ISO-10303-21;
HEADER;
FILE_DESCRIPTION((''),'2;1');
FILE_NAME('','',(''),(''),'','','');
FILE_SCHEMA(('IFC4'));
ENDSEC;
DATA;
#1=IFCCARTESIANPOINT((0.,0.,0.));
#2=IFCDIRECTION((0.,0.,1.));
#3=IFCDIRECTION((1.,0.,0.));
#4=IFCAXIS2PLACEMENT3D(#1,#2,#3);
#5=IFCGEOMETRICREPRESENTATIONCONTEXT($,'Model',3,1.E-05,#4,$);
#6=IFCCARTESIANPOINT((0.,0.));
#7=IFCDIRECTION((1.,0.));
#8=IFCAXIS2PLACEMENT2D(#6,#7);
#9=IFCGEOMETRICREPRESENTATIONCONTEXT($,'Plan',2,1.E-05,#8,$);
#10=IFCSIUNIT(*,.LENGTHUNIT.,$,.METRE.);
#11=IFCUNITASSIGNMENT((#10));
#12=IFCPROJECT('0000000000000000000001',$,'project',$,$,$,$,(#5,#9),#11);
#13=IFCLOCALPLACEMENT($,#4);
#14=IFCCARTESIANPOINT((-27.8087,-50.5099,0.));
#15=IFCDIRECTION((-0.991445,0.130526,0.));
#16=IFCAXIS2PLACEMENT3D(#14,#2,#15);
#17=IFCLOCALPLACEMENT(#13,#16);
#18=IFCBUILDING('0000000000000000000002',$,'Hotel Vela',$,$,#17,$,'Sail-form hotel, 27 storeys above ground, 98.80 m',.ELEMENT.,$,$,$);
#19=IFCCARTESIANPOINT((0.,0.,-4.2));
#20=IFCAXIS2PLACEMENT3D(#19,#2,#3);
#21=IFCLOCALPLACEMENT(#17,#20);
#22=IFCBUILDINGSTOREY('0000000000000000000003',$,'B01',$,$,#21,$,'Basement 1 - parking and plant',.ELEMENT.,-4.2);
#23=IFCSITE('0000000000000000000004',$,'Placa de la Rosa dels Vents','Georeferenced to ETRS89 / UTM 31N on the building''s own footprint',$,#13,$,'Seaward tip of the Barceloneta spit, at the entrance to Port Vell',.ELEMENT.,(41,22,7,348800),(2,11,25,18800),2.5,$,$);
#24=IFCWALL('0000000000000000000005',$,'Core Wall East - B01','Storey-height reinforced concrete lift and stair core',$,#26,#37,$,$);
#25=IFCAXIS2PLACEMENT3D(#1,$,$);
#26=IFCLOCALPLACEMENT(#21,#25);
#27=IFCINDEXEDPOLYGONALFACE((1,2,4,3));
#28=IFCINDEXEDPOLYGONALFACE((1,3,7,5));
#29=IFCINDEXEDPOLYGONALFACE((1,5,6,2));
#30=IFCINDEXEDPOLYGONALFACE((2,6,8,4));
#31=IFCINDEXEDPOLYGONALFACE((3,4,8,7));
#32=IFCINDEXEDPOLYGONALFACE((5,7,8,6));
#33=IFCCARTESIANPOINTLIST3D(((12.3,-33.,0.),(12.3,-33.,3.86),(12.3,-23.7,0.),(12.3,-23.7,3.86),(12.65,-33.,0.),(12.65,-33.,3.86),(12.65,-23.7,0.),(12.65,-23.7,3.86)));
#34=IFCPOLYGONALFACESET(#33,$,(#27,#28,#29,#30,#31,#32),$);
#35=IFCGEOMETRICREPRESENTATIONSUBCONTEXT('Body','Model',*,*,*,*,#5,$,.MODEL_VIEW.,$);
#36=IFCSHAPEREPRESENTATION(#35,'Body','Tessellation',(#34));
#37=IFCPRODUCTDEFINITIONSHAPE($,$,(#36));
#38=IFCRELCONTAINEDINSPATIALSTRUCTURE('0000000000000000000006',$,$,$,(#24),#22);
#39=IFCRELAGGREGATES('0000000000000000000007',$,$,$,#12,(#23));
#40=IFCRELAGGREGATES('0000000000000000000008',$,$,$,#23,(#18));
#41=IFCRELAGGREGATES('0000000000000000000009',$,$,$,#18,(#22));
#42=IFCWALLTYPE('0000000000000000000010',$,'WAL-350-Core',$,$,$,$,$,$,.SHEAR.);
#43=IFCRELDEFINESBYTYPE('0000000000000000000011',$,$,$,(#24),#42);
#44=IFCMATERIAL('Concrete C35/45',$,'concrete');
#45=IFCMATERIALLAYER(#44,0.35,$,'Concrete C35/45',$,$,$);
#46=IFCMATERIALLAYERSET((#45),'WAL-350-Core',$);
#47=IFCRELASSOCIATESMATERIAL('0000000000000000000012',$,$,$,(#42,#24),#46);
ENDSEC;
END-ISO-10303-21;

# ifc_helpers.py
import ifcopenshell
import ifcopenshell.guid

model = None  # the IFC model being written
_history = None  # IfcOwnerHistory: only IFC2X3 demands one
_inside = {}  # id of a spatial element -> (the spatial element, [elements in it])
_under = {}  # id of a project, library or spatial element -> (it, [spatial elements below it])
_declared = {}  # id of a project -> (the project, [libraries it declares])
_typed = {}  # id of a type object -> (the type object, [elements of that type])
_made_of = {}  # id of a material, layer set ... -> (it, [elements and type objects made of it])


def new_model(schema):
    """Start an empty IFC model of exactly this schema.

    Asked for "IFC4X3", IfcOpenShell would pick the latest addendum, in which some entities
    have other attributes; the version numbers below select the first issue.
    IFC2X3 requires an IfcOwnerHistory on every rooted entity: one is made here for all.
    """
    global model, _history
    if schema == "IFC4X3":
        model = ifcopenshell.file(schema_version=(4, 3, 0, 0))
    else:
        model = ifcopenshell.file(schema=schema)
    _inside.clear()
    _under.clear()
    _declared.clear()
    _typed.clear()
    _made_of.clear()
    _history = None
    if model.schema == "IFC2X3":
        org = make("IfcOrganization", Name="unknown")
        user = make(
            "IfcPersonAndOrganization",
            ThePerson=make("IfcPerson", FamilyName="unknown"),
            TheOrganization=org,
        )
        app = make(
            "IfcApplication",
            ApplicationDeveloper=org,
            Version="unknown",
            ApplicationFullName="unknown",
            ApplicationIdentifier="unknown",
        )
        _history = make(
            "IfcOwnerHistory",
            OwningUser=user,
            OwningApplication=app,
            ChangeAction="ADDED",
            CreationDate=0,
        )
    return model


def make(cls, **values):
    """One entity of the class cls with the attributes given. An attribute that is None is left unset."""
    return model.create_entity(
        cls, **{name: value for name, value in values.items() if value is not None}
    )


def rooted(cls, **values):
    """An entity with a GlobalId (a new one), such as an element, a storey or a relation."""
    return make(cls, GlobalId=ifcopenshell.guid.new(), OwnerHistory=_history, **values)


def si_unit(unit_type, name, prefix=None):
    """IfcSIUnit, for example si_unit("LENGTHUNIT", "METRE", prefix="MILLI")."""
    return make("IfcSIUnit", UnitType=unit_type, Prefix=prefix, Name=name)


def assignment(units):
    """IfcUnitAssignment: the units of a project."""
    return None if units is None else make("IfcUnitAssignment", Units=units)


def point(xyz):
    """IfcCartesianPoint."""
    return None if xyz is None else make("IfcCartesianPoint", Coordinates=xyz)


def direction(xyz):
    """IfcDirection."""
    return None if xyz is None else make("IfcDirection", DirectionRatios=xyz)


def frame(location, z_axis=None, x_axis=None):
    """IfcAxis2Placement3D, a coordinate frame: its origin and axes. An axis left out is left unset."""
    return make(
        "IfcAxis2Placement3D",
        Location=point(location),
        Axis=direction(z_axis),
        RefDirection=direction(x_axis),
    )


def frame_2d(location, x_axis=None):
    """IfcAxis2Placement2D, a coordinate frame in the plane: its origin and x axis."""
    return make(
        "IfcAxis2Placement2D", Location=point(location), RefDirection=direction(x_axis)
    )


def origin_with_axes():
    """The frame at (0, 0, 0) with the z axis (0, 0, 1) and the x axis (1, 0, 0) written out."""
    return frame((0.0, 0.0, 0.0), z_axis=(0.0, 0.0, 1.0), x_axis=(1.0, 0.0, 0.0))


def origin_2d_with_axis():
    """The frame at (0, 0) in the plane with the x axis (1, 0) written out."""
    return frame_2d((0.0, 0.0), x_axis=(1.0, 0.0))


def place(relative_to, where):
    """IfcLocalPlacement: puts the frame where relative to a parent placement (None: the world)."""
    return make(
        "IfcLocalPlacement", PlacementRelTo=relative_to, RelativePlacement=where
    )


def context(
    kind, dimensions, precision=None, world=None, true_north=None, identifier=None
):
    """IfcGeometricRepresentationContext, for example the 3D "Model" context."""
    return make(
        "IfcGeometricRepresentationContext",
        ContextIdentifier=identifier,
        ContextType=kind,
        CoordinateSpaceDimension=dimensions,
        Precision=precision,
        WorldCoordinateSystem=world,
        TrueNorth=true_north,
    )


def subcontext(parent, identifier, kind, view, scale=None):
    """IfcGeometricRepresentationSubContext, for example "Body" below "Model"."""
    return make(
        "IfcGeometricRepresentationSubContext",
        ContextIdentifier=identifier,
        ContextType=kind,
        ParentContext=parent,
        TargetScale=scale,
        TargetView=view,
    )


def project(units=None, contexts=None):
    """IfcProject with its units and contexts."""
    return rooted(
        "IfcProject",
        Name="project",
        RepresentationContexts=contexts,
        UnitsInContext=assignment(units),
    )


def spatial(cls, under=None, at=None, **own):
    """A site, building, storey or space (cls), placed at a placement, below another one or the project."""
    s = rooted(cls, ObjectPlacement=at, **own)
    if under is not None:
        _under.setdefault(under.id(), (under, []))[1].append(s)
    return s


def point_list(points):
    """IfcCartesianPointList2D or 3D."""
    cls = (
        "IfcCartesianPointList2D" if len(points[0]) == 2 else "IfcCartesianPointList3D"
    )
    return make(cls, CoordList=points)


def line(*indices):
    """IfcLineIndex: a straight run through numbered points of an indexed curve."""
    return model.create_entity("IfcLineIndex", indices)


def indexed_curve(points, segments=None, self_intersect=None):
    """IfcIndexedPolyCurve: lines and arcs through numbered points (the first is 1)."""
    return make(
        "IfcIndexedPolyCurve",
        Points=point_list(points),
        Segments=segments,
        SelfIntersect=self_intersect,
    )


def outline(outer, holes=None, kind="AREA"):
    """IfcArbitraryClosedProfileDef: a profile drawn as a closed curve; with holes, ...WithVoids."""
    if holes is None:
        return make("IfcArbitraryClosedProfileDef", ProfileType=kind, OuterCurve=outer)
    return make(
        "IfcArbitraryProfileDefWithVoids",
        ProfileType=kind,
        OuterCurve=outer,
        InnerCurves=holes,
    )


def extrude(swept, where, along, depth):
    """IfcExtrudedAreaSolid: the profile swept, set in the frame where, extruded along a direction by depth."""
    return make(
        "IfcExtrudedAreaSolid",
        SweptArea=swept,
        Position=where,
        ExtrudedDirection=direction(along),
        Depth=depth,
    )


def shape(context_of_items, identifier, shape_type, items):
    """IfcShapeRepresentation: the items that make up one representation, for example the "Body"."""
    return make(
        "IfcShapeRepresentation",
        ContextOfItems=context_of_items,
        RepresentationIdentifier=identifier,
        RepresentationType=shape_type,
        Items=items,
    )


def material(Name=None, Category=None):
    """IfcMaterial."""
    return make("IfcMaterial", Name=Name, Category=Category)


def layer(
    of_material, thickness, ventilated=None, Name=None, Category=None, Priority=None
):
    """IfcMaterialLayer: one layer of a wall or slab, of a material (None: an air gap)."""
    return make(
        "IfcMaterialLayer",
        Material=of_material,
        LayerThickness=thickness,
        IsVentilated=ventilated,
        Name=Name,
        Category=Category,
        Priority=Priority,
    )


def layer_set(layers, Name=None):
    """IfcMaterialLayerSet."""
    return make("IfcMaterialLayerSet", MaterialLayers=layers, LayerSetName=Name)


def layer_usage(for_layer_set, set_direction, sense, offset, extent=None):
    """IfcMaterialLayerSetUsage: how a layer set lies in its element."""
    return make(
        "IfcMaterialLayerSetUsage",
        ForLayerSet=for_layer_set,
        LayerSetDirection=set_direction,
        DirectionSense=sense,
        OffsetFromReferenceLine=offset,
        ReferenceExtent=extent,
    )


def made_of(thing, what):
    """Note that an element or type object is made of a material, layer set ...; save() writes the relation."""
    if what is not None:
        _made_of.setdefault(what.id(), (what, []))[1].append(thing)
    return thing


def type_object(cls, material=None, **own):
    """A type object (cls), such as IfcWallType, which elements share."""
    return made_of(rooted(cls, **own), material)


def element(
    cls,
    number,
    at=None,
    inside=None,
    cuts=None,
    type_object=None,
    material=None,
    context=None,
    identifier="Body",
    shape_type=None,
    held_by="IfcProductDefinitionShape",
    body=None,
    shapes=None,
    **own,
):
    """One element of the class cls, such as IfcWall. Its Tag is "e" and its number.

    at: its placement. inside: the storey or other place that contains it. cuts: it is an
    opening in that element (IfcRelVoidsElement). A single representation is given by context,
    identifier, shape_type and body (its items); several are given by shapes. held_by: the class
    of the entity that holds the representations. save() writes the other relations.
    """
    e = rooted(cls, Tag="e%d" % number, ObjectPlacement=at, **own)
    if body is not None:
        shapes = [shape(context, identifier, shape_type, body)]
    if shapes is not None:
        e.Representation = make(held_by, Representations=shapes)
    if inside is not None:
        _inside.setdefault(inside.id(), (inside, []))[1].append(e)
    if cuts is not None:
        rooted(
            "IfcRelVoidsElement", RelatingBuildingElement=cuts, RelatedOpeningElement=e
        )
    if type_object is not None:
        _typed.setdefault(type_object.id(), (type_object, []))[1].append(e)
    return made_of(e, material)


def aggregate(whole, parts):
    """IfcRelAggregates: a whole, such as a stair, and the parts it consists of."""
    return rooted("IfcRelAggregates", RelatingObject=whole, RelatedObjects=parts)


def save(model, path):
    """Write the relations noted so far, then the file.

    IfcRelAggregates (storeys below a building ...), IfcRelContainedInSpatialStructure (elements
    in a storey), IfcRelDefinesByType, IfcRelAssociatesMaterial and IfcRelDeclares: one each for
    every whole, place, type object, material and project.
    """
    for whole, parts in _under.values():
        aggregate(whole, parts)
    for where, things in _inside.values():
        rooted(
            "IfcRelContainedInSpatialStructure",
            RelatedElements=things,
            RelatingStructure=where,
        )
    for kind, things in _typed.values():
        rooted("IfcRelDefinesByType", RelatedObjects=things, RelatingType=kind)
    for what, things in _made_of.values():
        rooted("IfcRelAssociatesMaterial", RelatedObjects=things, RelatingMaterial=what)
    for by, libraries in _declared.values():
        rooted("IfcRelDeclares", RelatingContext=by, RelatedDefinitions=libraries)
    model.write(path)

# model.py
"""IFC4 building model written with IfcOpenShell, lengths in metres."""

from ifc_helpers import new_model, si_unit, frame, origin_with_axes, origin_2d_with_axis, place, context, subcontext, project, spatial, line, indexed_curve, outline, extrude, material, layer, layer_set, layer_usage, type_object, element, save


model = new_model("IFC4")

# Units and contexts
model_context = context("Model", 3, precision=1e-05, world=origin_with_axes())
plan_context = context("Plan", 2, precision=1e-05, world=origin_2d_with_axis())
body_context = subcontext(model_context, "Body", "Model", "MODEL_VIEW")
ifc_project = project(units=[si_unit("LENGTHUNIT", "METRE")], contexts=[model_context, plan_context])

# Site, building, storey
site_placement = place(None, origin_with_axes())
site = spatial("IfcSite", under=ifc_project, at=site_placement, Name="Placa de la Rosa dels Vents", Description="Georeferenced to ETRS89 / UTM 31N on the building's own footprint", LongName="Seaward tip of the Barceloneta spit, at the entrance to Port Vell", CompositionType="ELEMENT", RefLatitude=(41, 22, 7, 348800), RefLongitude=(2, 11, 25, 18800), RefElevation=2.5)
building_placement = place(site_placement, frame((-27.8087, -50.5099, 0.0), z_axis=(0.0, 0.0, 1.0), x_axis=(-0.991445, 0.130526, 0.0)))
building = spatial("IfcBuilding", under=site, at=building_placement, Name="Hotel Vela", LongName="Sail-form hotel, 27 storeys above ground, 98.80 m", CompositionType="ELEMENT")
storey_placement = place(building_placement, frame((0.0, 0.0, -4.2), z_axis=(0.0, 0.0, 1.0), x_axis=(1.0, 0.0, 0.0)))
storey = spatial("IfcBuildingStorey", under=building, at=storey_placement, Name="B01", LongName="Basement 1 - parking and plant", CompositionType="ELEMENT", Elevation=-4.2)

# Shared definitions
ifc_material = material(Name="Concrete C35/45", Category="concrete")

# Wall
ifc_layer_1 = layer(ifc_material, 0.35, Name="Concrete C35/45")
ifc_layer_set_1 = layer_set([ifc_layer_1], Name="WAL-350-Core")
wall_type = type_object("IfcWallType", Name="WAL-350-Core", PredefinedType="SHEAR", material=ifc_layer_set_1)
ifc_layer_usage_1 = layer_usage(ifc_layer_set_1, "AXIS2", "POSITIVE", 0.0)
wall_1_placement = place(storey_placement, frame((12.65, -33.0, 0.0), z_axis=(0.0, 0.0, 1.0), x_axis=(0.0, 1.0, 0.0)))
element("IfcWall", 1, at=wall_1_placement, inside=storey, type_object=wall_type, material=ifc_layer_usage_1, Name="Core Wall East - B01", Description="Storey-height reinforced concrete lift and stair core", context=body_context, shape_type="SweptSolid", body=[
    extrude(outline(indexed_curve([(0.0, 0.0), (9.3, 0.0), (9.3, 0.35), (0.0, 0.35)], segments=[line(1, 2, 3, 4, 1)])), origin_with_axes(), (0.0, 0.0, 1.0), 3.86),
])

save(model, "model.ifc")
